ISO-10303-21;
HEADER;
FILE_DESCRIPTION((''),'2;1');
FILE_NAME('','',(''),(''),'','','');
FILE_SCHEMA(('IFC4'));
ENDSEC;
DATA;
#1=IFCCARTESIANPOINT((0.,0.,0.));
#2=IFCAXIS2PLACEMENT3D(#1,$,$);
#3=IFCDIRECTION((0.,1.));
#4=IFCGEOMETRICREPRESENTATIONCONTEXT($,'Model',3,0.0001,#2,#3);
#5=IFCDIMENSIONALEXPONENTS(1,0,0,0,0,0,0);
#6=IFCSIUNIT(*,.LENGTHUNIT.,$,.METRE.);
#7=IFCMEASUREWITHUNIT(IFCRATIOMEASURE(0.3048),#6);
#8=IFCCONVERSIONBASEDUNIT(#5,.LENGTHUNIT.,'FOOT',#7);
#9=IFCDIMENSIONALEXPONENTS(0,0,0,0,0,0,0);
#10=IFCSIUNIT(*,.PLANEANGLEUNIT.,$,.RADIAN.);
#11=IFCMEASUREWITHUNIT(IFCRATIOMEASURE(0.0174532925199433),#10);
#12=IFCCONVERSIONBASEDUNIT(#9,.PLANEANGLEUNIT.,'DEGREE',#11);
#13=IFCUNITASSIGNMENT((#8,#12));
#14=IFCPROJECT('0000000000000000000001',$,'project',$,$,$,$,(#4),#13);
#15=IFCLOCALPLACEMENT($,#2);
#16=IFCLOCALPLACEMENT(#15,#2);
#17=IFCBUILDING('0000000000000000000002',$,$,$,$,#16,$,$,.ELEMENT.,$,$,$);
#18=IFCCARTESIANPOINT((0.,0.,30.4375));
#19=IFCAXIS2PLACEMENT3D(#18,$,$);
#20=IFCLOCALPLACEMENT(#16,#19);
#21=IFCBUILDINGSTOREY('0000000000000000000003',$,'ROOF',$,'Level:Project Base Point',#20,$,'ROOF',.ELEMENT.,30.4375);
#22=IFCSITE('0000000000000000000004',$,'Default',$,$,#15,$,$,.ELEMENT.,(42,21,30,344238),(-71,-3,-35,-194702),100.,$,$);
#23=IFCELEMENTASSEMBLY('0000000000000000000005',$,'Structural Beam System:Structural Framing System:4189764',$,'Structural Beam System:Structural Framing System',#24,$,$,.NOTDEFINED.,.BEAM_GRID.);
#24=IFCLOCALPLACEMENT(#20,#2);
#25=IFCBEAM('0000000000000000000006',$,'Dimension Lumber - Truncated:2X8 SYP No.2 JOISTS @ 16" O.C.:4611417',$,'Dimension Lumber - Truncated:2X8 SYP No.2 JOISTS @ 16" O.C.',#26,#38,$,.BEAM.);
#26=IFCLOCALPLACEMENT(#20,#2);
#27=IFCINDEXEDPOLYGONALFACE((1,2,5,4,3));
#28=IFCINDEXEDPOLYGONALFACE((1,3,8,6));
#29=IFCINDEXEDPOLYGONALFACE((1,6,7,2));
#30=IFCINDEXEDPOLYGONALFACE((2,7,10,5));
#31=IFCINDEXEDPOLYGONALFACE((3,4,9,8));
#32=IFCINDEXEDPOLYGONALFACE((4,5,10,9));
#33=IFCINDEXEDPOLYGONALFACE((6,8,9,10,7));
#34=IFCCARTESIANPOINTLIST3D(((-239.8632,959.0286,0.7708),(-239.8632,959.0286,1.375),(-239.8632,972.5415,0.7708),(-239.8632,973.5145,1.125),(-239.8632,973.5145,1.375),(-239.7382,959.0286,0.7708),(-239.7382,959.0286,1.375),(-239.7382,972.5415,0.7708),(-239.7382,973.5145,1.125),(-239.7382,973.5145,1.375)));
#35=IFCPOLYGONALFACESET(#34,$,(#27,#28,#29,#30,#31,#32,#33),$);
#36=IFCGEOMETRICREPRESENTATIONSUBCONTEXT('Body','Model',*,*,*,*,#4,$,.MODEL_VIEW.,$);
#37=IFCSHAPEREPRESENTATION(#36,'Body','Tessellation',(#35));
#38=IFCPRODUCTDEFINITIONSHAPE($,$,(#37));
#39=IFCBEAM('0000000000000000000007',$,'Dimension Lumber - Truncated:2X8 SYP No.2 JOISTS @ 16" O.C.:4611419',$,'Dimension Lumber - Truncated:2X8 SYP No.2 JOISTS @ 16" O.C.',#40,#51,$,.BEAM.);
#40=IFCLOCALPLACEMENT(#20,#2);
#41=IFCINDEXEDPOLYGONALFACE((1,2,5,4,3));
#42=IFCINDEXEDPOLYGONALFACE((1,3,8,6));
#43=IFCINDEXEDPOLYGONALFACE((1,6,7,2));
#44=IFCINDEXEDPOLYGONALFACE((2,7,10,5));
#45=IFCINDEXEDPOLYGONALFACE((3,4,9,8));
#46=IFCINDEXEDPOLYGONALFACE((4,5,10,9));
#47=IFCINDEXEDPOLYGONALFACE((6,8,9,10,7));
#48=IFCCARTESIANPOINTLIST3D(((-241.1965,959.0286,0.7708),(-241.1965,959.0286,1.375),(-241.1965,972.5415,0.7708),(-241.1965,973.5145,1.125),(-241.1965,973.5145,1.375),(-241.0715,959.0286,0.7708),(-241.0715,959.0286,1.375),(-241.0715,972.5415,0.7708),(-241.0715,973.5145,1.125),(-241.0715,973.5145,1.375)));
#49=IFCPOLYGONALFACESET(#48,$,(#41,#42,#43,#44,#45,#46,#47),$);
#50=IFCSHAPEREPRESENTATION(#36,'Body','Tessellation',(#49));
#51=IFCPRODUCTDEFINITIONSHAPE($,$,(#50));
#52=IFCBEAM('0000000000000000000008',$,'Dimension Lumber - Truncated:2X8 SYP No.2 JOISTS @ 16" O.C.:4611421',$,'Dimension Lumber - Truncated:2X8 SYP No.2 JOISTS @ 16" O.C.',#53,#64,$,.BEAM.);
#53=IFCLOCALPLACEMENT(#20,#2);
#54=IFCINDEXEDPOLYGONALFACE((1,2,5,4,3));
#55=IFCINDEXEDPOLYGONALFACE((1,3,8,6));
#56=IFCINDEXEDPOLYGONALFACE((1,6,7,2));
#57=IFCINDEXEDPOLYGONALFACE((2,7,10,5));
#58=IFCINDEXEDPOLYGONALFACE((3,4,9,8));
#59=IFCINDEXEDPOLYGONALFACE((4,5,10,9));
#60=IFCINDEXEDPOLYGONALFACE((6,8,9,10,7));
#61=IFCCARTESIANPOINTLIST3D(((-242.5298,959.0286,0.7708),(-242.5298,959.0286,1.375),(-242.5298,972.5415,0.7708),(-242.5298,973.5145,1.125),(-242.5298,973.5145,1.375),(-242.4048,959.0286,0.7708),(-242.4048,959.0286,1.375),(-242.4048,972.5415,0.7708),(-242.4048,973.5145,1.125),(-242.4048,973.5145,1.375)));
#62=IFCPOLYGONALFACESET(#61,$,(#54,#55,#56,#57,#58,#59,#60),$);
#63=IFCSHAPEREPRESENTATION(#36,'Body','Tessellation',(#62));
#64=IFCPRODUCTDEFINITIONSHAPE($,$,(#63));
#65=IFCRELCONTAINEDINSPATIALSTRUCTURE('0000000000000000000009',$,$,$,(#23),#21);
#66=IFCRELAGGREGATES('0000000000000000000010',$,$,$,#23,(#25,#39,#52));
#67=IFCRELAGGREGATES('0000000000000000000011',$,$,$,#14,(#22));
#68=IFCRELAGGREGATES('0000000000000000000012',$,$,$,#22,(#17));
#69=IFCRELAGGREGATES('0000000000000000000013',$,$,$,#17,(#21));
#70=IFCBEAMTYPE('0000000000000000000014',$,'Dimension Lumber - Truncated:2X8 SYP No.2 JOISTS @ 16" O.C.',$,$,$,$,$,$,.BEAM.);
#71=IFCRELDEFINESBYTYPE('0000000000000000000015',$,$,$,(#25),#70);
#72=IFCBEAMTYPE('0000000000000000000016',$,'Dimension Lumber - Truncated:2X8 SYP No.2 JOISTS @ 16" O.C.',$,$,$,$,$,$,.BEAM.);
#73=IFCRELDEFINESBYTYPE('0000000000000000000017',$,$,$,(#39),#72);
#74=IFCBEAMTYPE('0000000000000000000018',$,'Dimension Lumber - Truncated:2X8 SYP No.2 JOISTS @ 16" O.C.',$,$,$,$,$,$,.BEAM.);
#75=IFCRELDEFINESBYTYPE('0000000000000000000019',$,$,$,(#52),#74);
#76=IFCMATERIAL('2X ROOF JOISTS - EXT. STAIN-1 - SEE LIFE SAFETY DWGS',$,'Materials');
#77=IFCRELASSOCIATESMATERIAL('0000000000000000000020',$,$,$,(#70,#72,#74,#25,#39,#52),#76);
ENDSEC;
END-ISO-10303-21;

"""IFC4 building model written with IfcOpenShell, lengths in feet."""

from ifc_helpers import new_model, entity, si_unit, converted_unit, direction, frame, frame_2d, origin, place, context, subcontext, project, spatial, rectangle, extrude, clip, halfspace, source, transform, mapped, material, material_profile, profile_set, profile_usage, type_object, type_shapes, element, aggregate, save


model = new_model("IFC4")

# Units and contexts
model_context = context("Model", 3, precision=0.0001, world=origin(), true_north=direction((0.0, 1.0)))
body_context = subcontext(model_context, "Body", "Model", "MODEL_VIEW")
ifc_project = project(units=[converted_unit("LENGTHUNIT", "FOOT", entity("IfcRatioMeasure", 0.3048), si_unit("LENGTHUNIT", "METRE"), dimensions=[1, 0, 0, 0, 0, 0, 0]), converted_unit("PLANEANGLEUNIT", "DEGREE", entity("IfcRatioMeasure", 0.0174532925199433), si_unit("PLANEANGLEUNIT", "RADIAN"), dimensions=[0, 0, 0, 0, 0, 0, 0])], contexts=[model_context])

# Site, building, storey
site_placement = place(None, origin())
site = spatial("IfcSite", under=ifc_project, at=site_placement, Name="Default", CompositionType="ELEMENT", RefLatitude=(42, 21, 30, 344238), RefLongitude=(-71, -3, -35, -194702), RefElevation=100.0)
building_placement = place(site_placement, origin())
building = spatial("IfcBuilding", under=site, at=building_placement, CompositionType="ELEMENT")
storey_placement = place(building_placement, frame((0.0, 0.0, 30.4375)))
storey = spatial("IfcBuildingStorey", under=building, at=storey_placement, Name="ROOF", ObjectType="Level:Project Base Point", LongName="ROOF", CompositionType="ELEMENT", Elevation=30.4375)

# Element assembly, beams
assembly_1_placement = place(storey_placement, origin())
assembly_1 = element("IfcElementAssembly", 1, at=assembly_1_placement, inside=storey, Name="Structural Beam System:Structural Framing System:4189764", ObjectType="Structural Beam System:Structural Framing System", AssemblyPlace="NOTDEFINED", PredefinedType="BEAM_GRID")
ifc_material_1 = material(Name="2X ROOF JOISTS - EXT. STAIN-1 - SEE LIFE SAFETY DWGS", Category="Materials")
ifc_material_profile_1 = material_profile(ifc_material_1, rectangle(XDim=0.6042, YDim=0.125, at=frame_2d((0.0, 0.0), x_axis=(0.0, 1.0))), Name="2X8 SYP No.2 JOISTS @ 16\" O.C.")
ifc_profile_set_1 = profile_set([ifc_material_profile_1], Name="2X8 SYP No.2 JOISTS @ 16\" O.C.")
ifc_profile_usage_1 = profile_usage(ifc_profile_set_1, cardinal=8)
beam_type_1 = type_object("IfcBeamType", Name="Dimension Lumber - Truncated:2X8 SYP No.2 JOISTS @ 16\" O.C.", PredefinedType="BEAM", material=ifc_profile_set_1)
shared_shape_1 = source(origin(), body_context, "Body", "Clipping", [
    clip(extrude(rectangle(XDim=0.6042, YDim=0.125, at=frame_2d((0.0, 0.0), x_axis=(0.0, 1.0))), frame((-7.243, 0.0, 0.0), z_axis=(1.0, 0.0, 0.0), x_axis=(0.0, 1.0, 0.0)), (0.0, 0.0, 1.0), 14.4859), halfspace(frame((-6.2699, -0.0625, -0.3021), z_axis=(-0.34202, 0.0, -0.939693), x_axis=(0.0, 1.0, 0.0)), False)),
])
type_shapes(beam_type_1, [shared_shape_1])
beam_1_placement = place(assembly_1_placement, frame((-239.8007, 966.2716, 1.0729), z_axis=(0.0, 0.0, 1.0), x_axis=(0.0, -1.0, 0.0)))
beam_1 = element("IfcBeam", 2, at=beam_1_placement, type_object=beam_type_1, material=ifc_profile_usage_1, Name="Dimension Lumber - Truncated:2X8 SYP No.2 JOISTS @ 16\" O.C.:4611417", ObjectType="Dimension Lumber - Truncated:2X8 SYP No.2 JOISTS @ 16\" O.C.", PredefinedType="BEAM", context=body_context, shape_type="MappedRepresentation", body=[
    mapped(shared_shape_1, transform((0.0, 0.0, 0.0), scale=1.0)),
])
ifc_profile_usage_2 = profile_usage(ifc_profile_set_1, cardinal=8)
beam_type_2 = type_object("IfcBeamType", Name="Dimension Lumber - Truncated:2X8 SYP No.2 JOISTS @ 16\" O.C.", PredefinedType="BEAM", material=ifc_profile_set_1)
shared_shape_2 = source(origin(), body_context, "Body", "Clipping", [
    clip(extrude(rectangle(XDim=0.6042, YDim=0.125, at=frame_2d((0.0, 0.0), x_axis=(0.0, 1.0))), frame((-7.243, 0.0, 0.0), z_axis=(1.0, 0.0, 0.0), x_axis=(0.0, 1.0, 0.0)), (0.0, 0.0, 1.0), 14.4859), halfspace(frame((-6.2699, -0.0625, -0.3021), z_axis=(-0.34202, 0.0, -0.939693), x_axis=(0.0, 1.0, 0.0)), False)),
])
type_shapes(beam_type_2, [shared_shape_2])
beam_2_placement = place(assembly_1_placement, frame((-241.134, 966.2716, 1.0729), z_axis=(0.0, 0.0, 1.0), x_axis=(0.0, -1.0, 0.0)))
beam_2 = element("IfcBeam", 3, at=beam_2_placement, type_object=beam_type_2, material=ifc_profile_usage_2, Name="Dimension Lumber - Truncated:2X8 SYP No.2 JOISTS @ 16\" O.C.:4611419", ObjectType="Dimension Lumber - Truncated:2X8 SYP No.2 JOISTS @ 16\" O.C.", PredefinedType="BEAM", context=body_context, shape_type="MappedRepresentation", body=[
    mapped(shared_shape_2, transform((0.0, 0.0, 0.0), scale=1.0)),
])
ifc_profile_usage_3 = profile_usage(ifc_profile_set_1, cardinal=8)
beam_type_3 = type_object("IfcBeamType", Name="Dimension Lumber - Truncated:2X8 SYP No.2 JOISTS @ 16\" O.C.", PredefinedType="BEAM", material=ifc_profile_set_1)
shared_shape_3 = source(origin(), body_context, "Body", "Clipping", [
    clip(extrude(rectangle(XDim=0.6042, YDim=0.125, at=frame_2d((0.0, 0.0), x_axis=(0.0, 1.0))), frame((-7.243, 0.0, 0.0), z_axis=(1.0, 0.0, 0.0), x_axis=(0.0, 1.0, 0.0)), (0.0, 0.0, 1.0), 14.4859), halfspace(frame((-6.2699, -0.0625, -0.3021), z_axis=(-0.34202, 0.0, -0.939693), x_axis=(0.0, 1.0, 0.0)), False)),
])
type_shapes(beam_type_3, [shared_shape_3])
beam_3_placement = place(assembly_1_placement, frame((-242.4673, 966.2716, 1.0729), z_axis=(0.0, 0.0, 1.0), x_axis=(0.0, -1.0, 0.0)))
beam_3 = element("IfcBeam", 4, at=beam_3_placement, type_object=beam_type_3, material=ifc_profile_usage_3, Name="Dimension Lumber - Truncated:2X8 SYP No.2 JOISTS @ 16\" O.C.:4611421", ObjectType="Dimension Lumber - Truncated:2X8 SYP No.2 JOISTS @ 16\" O.C.", PredefinedType="BEAM", context=body_context, shape_type="MappedRepresentation", body=[
    mapped(shared_shape_3, transform((0.0, 0.0, 0.0), scale=1.0)),
])
aggregate(assembly_1, [beam_1, beam_2, beam_3])

save(model, "model.ifc")
